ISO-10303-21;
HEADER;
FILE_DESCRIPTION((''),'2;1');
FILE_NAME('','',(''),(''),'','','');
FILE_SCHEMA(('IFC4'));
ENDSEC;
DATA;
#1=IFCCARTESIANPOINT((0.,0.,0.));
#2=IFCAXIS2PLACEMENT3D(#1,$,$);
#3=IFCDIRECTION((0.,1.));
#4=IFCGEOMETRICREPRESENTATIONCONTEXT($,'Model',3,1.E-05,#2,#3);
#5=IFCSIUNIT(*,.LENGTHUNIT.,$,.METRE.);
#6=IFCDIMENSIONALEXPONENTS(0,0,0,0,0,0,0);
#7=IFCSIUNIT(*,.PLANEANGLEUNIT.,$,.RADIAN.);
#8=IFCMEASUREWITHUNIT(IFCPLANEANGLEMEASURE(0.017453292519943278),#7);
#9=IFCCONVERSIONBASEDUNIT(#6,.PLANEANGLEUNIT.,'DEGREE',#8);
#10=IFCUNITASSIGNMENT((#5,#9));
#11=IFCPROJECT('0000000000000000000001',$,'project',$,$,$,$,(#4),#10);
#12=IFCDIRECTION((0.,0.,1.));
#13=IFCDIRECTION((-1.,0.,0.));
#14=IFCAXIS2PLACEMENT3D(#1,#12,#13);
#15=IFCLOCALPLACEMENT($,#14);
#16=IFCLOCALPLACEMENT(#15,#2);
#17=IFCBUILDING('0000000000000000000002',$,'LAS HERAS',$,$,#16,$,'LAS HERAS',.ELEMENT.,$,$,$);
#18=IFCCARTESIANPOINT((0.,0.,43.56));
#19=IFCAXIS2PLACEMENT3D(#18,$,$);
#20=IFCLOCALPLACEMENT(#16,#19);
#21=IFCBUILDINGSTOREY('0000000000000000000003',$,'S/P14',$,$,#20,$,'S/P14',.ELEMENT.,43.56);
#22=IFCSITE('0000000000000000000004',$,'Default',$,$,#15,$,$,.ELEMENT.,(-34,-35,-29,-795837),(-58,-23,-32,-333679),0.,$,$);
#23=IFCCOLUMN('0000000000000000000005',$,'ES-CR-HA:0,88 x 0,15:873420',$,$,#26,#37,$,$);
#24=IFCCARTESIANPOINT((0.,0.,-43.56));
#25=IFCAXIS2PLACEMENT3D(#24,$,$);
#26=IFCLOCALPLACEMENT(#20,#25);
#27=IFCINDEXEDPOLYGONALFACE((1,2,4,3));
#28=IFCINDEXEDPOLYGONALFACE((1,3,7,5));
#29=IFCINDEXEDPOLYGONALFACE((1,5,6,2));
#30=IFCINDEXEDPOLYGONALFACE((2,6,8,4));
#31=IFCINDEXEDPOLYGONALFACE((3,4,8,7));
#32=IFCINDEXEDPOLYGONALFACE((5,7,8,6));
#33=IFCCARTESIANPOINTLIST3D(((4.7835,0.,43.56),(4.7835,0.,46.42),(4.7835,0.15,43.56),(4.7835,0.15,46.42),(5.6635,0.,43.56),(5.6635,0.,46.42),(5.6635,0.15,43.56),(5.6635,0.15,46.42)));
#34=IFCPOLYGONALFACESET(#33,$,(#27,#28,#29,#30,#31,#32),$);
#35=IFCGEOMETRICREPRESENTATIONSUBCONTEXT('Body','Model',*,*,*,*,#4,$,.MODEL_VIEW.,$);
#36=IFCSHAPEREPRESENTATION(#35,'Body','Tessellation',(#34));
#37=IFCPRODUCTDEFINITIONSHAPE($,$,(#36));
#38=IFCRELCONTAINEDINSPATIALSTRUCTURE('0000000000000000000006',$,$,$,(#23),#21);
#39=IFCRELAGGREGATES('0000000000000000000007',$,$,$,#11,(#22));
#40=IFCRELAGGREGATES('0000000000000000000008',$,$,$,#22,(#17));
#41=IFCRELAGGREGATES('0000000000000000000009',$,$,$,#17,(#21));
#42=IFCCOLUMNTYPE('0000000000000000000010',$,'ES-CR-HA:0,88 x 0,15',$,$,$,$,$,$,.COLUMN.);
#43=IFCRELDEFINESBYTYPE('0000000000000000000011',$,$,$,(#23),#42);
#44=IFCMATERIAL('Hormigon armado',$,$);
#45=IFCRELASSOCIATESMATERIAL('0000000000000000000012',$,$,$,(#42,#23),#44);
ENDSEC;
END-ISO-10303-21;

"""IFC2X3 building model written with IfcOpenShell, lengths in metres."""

from ifc_helpers import new_model, entity, si_unit, converted_unit, direction, frame, frame_2d, origin, place, context, subcontext, project, spatial, rectangle, extrude, source, transform, mapped, material, type_object, type_shapes, element, save


model = new_model("IFC2X3")

# Units and contexts
model_context = context("Model", 3, precision=1e-05, world=origin(), true_north=direction((0.0, 1.0)))
body_context = subcontext(model_context, "Body", "Model", "MODEL_VIEW")
ifc_project = project(units=[si_unit("LENGTHUNIT", "METRE"), converted_unit("PLANEANGLEUNIT", "DEGREE", entity("IfcPlaneAngleMeasure", 0.017453292519943278), si_unit("PLANEANGLEUNIT", "RADIAN"), dimensions=[0, 0, 0, 0, 0, 0, 0])], contexts=[model_context])

# Site, building, storey
site_placement = place(None, frame((0.0, 0.0, 0.0), z_axis=(0.0, 0.0, 1.0), x_axis=(-1.0, 0.0, 0.0)))
site = spatial("IfcSite", under=ifc_project, at=site_placement, Name="Default", CompositionType="ELEMENT", RefLatitude=(-34, -35, -29, -795837), RefLongitude=(-58, -23, -32, -333679), RefElevation=0.0)
building_placement = place(site_placement, origin())
building = spatial("IfcBuilding", under=site, at=building_placement, Name="LAS HERAS", LongName="LAS HERAS", CompositionType="ELEMENT")
storey_placement = place(building_placement, frame((0.0, 0.0, 43.56)))
storey = spatial("IfcBuildingStorey", under=building, at=storey_placement, Name="S/P14", LongName="S/P14", CompositionType="ELEMENT", Elevation=43.56)

# Column
ifc_material = material(Name="Hormigon armado")
column_type_1 = type_object("IfcColumnType", Name="ES-CR-HA:0,88 x 0,15", PredefinedType="COLUMN", material=ifc_material)
shared_shape_1 = source(origin(), body_context, "Body", "SweptSolid", [
    extrude(rectangle(XDim=0.15, YDim=0.88, at=frame_2d((0.0, 0.0), x_axis=(1.0, 0.0))), frame((5.2235, 0.075, 43.56), z_axis=(0.0, 0.0, 1.0), x_axis=(0.0, -1.0, 0.0)), (0.0, 0.0, 1.0), 2.86),
])
type_shapes(column_type_1, [shared_shape_1])
column_1_placement = place(storey_placement, frame((0.0, 0.0, -43.56)))
element("IfcColumn", 1, at=column_1_placement, inside=storey, type_object=column_type_1, material=ifc_material, Name="ES-CR-HA:0,88 x 0,15:873420", context=body_context, shape_type="MappedRepresentation", body=[
    mapped(shared_shape_1, transform((0.0, 0.0, 0.0), scale=1.0)),
])

save(model, "model.ifc")
